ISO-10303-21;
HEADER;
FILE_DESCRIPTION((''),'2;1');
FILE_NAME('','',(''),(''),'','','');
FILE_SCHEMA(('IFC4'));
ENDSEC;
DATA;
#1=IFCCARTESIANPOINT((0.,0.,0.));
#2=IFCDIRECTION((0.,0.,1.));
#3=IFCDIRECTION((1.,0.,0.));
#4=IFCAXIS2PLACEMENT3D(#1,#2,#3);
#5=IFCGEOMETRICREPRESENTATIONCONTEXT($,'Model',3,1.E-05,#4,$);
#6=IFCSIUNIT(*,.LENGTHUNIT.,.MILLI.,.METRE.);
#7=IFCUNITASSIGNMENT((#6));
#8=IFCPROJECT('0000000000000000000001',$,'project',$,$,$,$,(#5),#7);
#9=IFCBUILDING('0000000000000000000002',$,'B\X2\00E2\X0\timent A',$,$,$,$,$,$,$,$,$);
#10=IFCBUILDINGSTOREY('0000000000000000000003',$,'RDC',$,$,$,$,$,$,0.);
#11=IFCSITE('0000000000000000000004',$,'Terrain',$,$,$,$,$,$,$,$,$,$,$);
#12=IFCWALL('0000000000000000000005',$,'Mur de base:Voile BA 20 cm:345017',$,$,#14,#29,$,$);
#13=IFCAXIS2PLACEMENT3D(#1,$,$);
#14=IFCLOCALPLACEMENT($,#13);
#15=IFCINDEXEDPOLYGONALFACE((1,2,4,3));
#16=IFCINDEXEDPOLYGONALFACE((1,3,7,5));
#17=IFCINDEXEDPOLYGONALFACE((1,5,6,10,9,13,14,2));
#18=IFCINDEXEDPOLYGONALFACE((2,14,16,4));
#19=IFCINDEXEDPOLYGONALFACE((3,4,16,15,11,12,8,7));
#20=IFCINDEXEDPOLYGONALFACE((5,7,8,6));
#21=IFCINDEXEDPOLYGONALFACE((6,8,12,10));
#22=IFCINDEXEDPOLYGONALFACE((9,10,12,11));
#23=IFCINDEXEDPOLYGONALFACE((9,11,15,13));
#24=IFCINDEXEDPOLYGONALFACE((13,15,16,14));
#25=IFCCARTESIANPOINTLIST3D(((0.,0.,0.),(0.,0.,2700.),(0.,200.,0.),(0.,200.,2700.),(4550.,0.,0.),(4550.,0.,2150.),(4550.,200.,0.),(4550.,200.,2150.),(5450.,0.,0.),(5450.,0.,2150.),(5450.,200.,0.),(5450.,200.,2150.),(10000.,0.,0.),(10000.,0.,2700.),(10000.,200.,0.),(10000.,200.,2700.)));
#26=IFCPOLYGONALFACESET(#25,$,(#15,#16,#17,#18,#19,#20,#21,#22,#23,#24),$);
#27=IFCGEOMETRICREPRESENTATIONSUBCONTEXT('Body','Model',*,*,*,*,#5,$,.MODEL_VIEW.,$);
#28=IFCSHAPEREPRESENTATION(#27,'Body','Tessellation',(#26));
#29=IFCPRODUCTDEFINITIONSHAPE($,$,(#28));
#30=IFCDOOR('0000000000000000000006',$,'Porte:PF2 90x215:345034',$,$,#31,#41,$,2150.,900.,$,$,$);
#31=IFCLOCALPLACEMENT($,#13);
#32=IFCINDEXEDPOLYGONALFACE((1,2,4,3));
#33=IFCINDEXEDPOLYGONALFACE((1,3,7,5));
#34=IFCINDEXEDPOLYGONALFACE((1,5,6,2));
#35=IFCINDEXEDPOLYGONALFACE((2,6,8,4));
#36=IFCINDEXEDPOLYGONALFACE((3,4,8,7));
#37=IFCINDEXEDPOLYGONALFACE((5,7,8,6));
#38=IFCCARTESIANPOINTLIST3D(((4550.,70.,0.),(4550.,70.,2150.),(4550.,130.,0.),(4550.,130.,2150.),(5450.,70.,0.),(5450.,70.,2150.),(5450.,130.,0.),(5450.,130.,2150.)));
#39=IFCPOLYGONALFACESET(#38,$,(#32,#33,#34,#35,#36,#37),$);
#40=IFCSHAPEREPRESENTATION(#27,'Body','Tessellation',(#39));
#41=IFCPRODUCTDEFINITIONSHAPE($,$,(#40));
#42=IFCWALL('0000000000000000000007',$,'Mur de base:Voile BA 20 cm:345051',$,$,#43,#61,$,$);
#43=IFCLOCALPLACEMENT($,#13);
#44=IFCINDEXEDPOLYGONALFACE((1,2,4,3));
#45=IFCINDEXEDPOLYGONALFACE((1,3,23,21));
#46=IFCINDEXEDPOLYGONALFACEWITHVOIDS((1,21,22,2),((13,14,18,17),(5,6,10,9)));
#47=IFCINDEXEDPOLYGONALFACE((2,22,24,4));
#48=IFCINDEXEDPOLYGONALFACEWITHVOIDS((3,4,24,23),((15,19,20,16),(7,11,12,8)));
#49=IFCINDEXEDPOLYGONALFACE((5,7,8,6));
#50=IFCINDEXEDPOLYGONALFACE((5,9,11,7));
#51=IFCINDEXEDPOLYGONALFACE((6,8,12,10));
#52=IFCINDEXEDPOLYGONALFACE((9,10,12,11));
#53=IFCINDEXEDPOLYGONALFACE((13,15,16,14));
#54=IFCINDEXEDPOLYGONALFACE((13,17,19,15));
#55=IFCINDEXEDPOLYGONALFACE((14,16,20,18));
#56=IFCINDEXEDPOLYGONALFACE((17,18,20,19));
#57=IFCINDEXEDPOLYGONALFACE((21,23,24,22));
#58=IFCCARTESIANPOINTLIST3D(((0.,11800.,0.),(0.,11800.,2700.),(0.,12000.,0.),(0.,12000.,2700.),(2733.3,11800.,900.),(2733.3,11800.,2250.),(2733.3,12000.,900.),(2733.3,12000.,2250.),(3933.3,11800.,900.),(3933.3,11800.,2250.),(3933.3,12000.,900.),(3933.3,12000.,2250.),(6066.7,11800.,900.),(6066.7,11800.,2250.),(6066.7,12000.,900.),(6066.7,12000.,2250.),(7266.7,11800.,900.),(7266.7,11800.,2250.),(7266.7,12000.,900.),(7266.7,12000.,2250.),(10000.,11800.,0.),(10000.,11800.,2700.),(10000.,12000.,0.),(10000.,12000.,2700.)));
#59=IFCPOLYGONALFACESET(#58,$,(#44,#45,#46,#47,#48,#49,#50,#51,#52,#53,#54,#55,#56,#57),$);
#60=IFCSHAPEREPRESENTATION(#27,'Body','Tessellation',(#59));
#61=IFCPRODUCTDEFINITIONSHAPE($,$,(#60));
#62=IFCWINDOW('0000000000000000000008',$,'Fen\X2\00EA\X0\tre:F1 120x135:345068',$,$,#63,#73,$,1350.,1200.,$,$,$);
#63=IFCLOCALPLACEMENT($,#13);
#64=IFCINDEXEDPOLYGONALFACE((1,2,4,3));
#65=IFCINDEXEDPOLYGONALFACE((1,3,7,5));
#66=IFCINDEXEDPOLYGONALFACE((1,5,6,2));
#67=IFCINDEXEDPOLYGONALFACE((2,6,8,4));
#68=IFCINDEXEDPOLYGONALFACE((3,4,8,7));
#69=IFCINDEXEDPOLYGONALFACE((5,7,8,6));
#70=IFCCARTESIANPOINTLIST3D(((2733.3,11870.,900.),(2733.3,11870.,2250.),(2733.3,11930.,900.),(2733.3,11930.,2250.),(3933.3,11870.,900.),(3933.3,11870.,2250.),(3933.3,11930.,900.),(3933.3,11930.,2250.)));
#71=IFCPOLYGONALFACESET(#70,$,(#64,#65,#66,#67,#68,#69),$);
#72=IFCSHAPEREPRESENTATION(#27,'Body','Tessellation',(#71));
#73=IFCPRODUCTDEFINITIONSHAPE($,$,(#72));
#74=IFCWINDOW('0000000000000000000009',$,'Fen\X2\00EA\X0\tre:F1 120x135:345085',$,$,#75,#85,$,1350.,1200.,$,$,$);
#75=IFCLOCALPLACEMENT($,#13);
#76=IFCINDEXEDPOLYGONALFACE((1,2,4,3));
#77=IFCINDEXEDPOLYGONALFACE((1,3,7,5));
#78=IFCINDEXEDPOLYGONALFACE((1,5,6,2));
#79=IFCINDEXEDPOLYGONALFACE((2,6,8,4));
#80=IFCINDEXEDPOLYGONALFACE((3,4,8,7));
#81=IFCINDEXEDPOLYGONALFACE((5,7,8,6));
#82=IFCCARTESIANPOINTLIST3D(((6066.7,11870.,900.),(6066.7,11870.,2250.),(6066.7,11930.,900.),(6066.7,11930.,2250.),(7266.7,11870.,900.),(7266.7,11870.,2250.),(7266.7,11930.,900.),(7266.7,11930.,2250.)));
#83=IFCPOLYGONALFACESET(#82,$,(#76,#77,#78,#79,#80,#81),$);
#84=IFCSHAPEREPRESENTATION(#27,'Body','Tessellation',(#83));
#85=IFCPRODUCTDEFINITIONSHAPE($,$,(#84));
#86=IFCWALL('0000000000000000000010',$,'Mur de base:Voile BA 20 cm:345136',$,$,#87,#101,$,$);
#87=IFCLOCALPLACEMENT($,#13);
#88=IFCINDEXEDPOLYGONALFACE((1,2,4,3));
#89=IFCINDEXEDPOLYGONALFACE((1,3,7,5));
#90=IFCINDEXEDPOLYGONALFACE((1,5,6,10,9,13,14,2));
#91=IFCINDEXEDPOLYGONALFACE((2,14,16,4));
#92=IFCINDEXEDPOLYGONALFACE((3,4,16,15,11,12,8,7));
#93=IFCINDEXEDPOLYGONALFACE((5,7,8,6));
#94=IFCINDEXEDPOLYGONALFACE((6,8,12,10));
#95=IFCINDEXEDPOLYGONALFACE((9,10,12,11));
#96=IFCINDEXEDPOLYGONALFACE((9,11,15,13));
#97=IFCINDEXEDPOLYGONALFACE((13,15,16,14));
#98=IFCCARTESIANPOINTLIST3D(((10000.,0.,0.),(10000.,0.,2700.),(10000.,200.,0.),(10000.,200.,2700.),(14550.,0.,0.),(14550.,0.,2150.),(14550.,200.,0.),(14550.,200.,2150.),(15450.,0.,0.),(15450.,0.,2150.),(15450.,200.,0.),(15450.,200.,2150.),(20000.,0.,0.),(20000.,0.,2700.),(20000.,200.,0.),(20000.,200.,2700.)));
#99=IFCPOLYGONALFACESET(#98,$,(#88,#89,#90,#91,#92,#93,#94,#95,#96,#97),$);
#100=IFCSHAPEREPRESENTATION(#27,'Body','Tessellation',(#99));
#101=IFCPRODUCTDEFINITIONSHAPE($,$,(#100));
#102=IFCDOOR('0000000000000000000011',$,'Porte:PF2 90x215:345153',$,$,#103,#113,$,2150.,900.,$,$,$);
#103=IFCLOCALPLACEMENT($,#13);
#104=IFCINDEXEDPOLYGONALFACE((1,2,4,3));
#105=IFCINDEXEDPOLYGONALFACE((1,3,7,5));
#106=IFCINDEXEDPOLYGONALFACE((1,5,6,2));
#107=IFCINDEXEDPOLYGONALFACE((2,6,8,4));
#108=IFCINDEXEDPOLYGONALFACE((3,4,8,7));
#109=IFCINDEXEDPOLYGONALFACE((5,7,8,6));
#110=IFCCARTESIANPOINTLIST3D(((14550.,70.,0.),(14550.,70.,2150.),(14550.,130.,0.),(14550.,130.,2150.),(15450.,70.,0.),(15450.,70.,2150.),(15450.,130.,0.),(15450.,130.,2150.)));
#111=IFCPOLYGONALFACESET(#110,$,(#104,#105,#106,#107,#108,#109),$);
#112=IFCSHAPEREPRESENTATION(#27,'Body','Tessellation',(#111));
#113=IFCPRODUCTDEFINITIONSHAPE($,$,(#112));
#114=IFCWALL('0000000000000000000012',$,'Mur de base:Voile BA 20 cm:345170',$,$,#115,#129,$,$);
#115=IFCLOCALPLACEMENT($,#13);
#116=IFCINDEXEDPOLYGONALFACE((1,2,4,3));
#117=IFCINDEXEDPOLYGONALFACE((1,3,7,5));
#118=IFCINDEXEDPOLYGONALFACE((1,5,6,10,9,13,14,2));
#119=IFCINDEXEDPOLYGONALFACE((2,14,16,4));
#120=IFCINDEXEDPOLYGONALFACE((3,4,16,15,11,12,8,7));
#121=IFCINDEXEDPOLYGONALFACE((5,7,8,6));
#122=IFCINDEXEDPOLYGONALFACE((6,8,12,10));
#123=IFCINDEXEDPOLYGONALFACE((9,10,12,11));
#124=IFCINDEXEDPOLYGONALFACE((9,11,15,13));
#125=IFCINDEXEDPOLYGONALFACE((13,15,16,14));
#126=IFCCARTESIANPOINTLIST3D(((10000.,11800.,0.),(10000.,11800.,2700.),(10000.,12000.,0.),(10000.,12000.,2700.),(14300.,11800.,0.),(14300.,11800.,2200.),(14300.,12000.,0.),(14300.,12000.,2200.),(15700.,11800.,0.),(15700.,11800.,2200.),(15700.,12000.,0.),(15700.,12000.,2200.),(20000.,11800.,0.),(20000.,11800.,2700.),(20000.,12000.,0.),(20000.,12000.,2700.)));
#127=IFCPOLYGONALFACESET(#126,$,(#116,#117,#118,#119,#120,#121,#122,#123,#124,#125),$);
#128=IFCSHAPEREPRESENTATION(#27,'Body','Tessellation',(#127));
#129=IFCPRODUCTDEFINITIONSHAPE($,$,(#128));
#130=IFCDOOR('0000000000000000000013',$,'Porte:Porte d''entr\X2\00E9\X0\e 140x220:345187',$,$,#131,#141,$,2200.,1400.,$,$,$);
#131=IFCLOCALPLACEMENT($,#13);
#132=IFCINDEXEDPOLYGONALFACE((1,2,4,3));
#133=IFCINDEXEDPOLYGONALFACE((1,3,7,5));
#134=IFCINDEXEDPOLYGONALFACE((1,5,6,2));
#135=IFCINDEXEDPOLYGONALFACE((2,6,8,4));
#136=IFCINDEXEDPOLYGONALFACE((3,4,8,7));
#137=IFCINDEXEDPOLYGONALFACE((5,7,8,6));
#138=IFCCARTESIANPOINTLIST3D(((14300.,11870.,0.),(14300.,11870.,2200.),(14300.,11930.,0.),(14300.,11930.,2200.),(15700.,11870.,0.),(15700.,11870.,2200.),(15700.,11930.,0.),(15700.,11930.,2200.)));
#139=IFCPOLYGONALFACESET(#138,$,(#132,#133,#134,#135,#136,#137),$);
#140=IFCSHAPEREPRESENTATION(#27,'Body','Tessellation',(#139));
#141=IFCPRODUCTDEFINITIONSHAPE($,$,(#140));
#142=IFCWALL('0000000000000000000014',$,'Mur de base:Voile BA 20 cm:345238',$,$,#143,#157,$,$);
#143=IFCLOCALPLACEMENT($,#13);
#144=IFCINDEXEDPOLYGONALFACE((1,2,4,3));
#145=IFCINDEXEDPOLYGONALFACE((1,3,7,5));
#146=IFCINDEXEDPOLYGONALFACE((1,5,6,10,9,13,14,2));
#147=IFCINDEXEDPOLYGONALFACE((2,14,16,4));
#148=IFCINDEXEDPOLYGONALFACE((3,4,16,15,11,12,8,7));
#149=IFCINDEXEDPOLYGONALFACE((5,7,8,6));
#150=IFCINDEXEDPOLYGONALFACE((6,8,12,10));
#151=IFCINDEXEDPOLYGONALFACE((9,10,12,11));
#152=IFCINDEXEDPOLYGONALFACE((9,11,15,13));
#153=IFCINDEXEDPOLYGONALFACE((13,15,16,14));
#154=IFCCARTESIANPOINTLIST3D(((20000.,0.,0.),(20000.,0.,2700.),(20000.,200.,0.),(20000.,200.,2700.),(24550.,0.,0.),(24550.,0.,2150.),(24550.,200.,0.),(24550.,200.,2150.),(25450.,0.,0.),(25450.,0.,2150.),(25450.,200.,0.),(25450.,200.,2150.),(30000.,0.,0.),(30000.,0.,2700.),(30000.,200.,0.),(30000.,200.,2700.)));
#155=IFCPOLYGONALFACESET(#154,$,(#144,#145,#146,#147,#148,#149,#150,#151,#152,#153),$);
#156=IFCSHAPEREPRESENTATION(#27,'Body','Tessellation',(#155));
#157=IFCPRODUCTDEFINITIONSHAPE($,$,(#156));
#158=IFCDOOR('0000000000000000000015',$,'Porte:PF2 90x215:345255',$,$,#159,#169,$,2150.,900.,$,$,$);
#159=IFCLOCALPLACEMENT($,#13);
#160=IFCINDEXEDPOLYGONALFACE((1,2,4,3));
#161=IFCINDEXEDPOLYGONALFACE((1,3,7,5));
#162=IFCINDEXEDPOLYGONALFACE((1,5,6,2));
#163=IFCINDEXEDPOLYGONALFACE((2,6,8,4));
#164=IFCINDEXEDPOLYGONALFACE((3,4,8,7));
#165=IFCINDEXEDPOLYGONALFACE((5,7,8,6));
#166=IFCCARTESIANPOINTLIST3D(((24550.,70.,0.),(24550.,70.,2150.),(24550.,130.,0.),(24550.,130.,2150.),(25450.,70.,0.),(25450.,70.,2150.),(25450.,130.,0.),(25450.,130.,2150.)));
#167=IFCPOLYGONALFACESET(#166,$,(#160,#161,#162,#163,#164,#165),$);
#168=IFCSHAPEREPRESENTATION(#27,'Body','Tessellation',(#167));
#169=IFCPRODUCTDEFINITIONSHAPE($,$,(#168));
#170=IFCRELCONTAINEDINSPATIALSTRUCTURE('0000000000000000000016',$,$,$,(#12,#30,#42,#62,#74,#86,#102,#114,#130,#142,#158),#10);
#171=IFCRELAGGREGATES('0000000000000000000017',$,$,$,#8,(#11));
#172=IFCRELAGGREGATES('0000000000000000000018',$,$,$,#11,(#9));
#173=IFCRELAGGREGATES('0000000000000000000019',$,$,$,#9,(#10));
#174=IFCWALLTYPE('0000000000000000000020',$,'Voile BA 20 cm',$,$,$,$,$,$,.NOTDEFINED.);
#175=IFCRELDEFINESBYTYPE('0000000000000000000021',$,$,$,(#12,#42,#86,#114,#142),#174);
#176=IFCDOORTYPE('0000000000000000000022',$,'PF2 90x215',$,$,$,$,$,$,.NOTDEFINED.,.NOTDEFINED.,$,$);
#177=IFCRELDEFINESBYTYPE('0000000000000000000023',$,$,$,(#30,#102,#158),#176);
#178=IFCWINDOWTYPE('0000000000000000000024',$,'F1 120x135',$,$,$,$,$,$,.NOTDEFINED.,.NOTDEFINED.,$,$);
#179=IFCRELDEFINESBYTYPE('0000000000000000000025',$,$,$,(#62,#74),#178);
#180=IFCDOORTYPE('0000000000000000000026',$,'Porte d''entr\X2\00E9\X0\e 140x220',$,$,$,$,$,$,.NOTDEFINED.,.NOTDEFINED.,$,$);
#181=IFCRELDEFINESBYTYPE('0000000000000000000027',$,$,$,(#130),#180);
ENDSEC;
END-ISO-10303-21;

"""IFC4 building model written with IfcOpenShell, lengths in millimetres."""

from ifc_helpers import new_model, si_unit, frame, frame_2d, origin_with_axes, place, context, subcontext, project, spatial, rectangle, extrude, type_object, element, fill, save


model = new_model("IFC4")

# Units and contexts
model_context = context("Model", 3, precision=1e-05, world=origin_with_axes())
body_context = subcontext(model_context, "Body", "Model", "MODEL_VIEW")
ifc_project = project(units=[si_unit("LENGTHUNIT", "METRE", prefix="MILLI")], contexts=[model_context])

# Site, building, storey
site = spatial("IfcSite", under=ifc_project, Name="Terrain")
building = spatial("IfcBuilding", under=site, Name="Bâtiment A")
storey = spatial("IfcBuildingStorey", under=building, Name="RDC", Elevation=0.0)

# Wall, opening, door
wall_type_1 = type_object("IfcWallType", Name="Voile BA 20 cm", PredefinedType="NOTDEFINED")
wall_1_placement = place(None, origin_with_axes())
wall_1 = element("IfcWall", 1, at=wall_1_placement, inside=storey, type_object=wall_type_1, Name="Mur de base:Voile BA 20 cm:345017", context=body_context, shape_type="SweptSolid", body=[
    extrude(rectangle(XDim=10000.0, YDim=200.0, at=frame_2d((5000.0, 100.0))), origin_with_axes(), (0.0, 0.0, 1.0), 2700.0),
])
opening_1_placement = place(None, origin_with_axes())
opening_1 = element("IfcOpeningElement", 2, at=opening_1_placement, cuts=wall_1, context=body_context, shape_type="SweptSolid", body=[
    extrude(rectangle(XDim=900.0, YDim=320.0, at=frame_2d((5000.0, 100.0))), origin_with_axes(), (0.0, 0.0, 1.0), 2150.0),
])
door_type_1 = type_object("IfcDoorType", Name="PF2 90x215", OperationType="NOTDEFINED", PredefinedType="NOTDEFINED")
door_1_placement = place(None, origin_with_axes())
door_1 = element("IfcDoor", 3, at=door_1_placement, inside=storey, type_object=door_type_1, Name="Porte:PF2 90x215:345034", OverallHeight=2150.0, OverallWidth=900.0, context=body_context, shape_type="SweptSolid", body=[
    extrude(rectangle(XDim=900.0, YDim=60.0, at=frame_2d((5000.0, 100.0))), origin_with_axes(), (0.0, 0.0, 1.0), 2150.0),
])
fill(opening_1, door_1)

# Wall, openings, windows
wall_2_placement = place(None, origin_with_axes())
wall_2 = element("IfcWall", 4, at=wall_2_placement, inside=storey, type_object=wall_type_1, Name="Mur de base:Voile BA 20 cm:345051", context=body_context, shape_type="SweptSolid", body=[
    extrude(rectangle(XDim=10000.0, YDim=200.0, at=frame_2d((5000.0, 11900.0))), origin_with_axes(), (0.0, 0.0, 1.0), 2700.0),
])
opening_2_placement = place(None, origin_with_axes())
opening_2 = element("IfcOpeningElement", 5, at=opening_2_placement, cuts=wall_2, context=body_context, shape_type="SweptSolid", body=[
    extrude(rectangle(XDim=1200.0, YDim=320.0, at=frame_2d((3333.3, 11900.0))), frame((0.0, 0.0, 900.0), z_axis=(0.0, 0.0, 1.0), x_axis=(1.0, 0.0, 0.0)), (0.0, 0.0, 1.0), 1350.0),
])
opening_3_placement = place(None, origin_with_axes())
opening_3 = element("IfcOpeningElement", 6, at=opening_3_placement, cuts=wall_2, context=body_context, shape_type="SweptSolid", body=[
    extrude(rectangle(XDim=1200.0, YDim=320.0, at=frame_2d((6666.7, 11900.0))), frame((0.0, 0.0, 900.0), z_axis=(0.0, 0.0, 1.0), x_axis=(1.0, 0.0, 0.0)), (0.0, 0.0, 1.0), 1350.0),
])
window_type = type_object("IfcWindowType", Name="F1 120x135", PartitioningType="NOTDEFINED", PredefinedType="NOTDEFINED")
window_1_placement = place(None, origin_with_axes())
window_1 = element("IfcWindow", 7, at=window_1_placement, inside=storey, type_object=window_type, Name="Fenêtre:F1 120x135:345068", OverallHeight=1350.0, OverallWidth=1200.0, context=body_context, shape_type="SweptSolid", body=[
    extrude(rectangle(XDim=1200.0, YDim=60.0, at=frame_2d((3333.3, 11900.0))), frame((0.0, 0.0, 900.0), z_axis=(0.0, 0.0, 1.0), x_axis=(1.0, 0.0, 0.0)), (0.0, 0.0, 1.0), 1350.0),
])
fill(opening_2, window_1)
window_2_placement = place(None, origin_with_axes())
window_2 = element("IfcWindow", 8, at=window_2_placement, inside=storey, type_object=window_type, Name="Fenêtre:F1 120x135:345085", OverallHeight=1350.0, OverallWidth=1200.0, context=body_context, shape_type="SweptSolid", body=[
    extrude(rectangle(XDim=1200.0, YDim=60.0, at=frame_2d((6666.7, 11900.0))), frame((0.0, 0.0, 900.0), z_axis=(0.0, 0.0, 1.0), x_axis=(1.0, 0.0, 0.0)), (0.0, 0.0, 1.0), 1350.0),
])
fill(opening_3, window_2)

# Walls, openings, doors
wall_3_placement = place(None, origin_with_axes())
wall_3 = element("IfcWall", 9, at=wall_3_placement, inside=storey, type_object=wall_type_1, Name="Mur de base:Voile BA 20 cm:345136", context=body_context, shape_type="SweptSolid", body=[
    extrude(rectangle(XDim=10000.0, YDim=200.0, at=frame_2d((15000.0, 100.0))), origin_with_axes(), (0.0, 0.0, 1.0), 2700.0),
])
opening_4_placement = place(None, origin_with_axes())
opening_4 = element("IfcOpeningElement", 10, at=opening_4_placement, cuts=wall_3, context=body_context, shape_type="SweptSolid", body=[
    extrude(rectangle(XDim=900.0, YDim=320.0, at=frame_2d((15000.0, 100.0))), origin_with_axes(), (0.0, 0.0, 1.0), 2150.0),
])
door_2_placement = place(None, origin_with_axes())
door_2 = element("IfcDoor", 11, at=door_2_placement, inside=storey, type_object=door_type_1, Name="Porte:PF2 90x215:345153", OverallHeight=2150.0, OverallWidth=900.0, context=body_context, shape_type="SweptSolid", body=[
    extrude(rectangle(XDim=900.0, YDim=60.0, at=frame_2d((15000.0, 100.0))), origin_with_axes(), (0.0, 0.0, 1.0), 2150.0),
])
fill(opening_4, door_2)
wall_4_placement = place(None, origin_with_axes())
wall_4 = element("IfcWall", 12, at=wall_4_placement, inside=storey, type_object=wall_type_1, Name="Mur de base:Voile BA 20 cm:345170", context=body_context, shape_type="SweptSolid", body=[
    extrude(rectangle(XDim=10000.0, YDim=200.0, at=frame_2d((15000.0, 11900.0))), origin_with_axes(), (0.0, 0.0, 1.0), 2700.0),
])
opening_5_placement = place(None, origin_with_axes())
opening_5 = element("IfcOpeningElement", 13, at=opening_5_placement, cuts=wall_4, context=body_context, shape_type="SweptSolid", body=[
    extrude(rectangle(XDim=1400.0, YDim=320.0, at=frame_2d((15000.0, 11900.0))), origin_with_axes(), (0.0, 0.0, 1.0), 2200.0),
])
door_type_2 = type_object("IfcDoorType", Name="Porte d'entrée 140x220", OperationType="NOTDEFINED", PredefinedType="NOTDEFINED")
door_3_placement = place(None, origin_with_axes())
door_3 = element("IfcDoor", 14, at=door_3_placement, inside=storey, type_object=door_type_2, Name="Porte:Porte d'entrée 140x220:345187", OverallHeight=2200.0, OverallWidth=1400.0, context=body_context, shape_type="SweptSolid", body=[
    extrude(rectangle(XDim=1400.0, YDim=60.0, at=frame_2d((15000.0, 11900.0))), origin_with_axes(), (0.0, 0.0, 1.0), 2200.0),
])
fill(opening_5, door_3)
wall_5_placement = place(None, origin_with_axes())
wall_5 = element("IfcWall", 15, at=wall_5_placement, inside=storey, type_object=wall_type_1, Name="Mur de base:Voile BA 20 cm:345238", context=body_context, shape_type="SweptSolid", body=[
    extrude(rectangle(XDim=10000.0, YDim=200.0, at=frame_2d((25000.0, 100.0))), origin_with_axes(), (0.0, 0.0, 1.0), 2700.0),
])
opening_6_placement = place(None, origin_with_axes())
opening_6 = element("IfcOpeningElement", 16, at=opening_6_placement, cuts=wall_5, context=body_context, shape_type="SweptSolid", body=[
    extrude(rectangle(XDim=900.0, YDim=320.0, at=frame_2d((25000.0, 100.0))), origin_with_axes(), (0.0, 0.0, 1.0), 2150.0),
])
door_4_placement = place(None, origin_with_axes())
door_4 = element("IfcDoor", 17, at=door_4_placement, inside=storey, type_object=door_type_1, Name="Porte:PF2 90x215:345255", OverallHeight=2150.0, OverallWidth=900.0, context=body_context, shape_type="SweptSolid", body=[
    extrude(rectangle(XDim=900.0, YDim=60.0, at=frame_2d((25000.0, 100.0))), origin_with_axes(), (0.0, 0.0, 1.0), 2150.0),
])
fill(opening_6, door_4)

save(model, "model.ifc")
